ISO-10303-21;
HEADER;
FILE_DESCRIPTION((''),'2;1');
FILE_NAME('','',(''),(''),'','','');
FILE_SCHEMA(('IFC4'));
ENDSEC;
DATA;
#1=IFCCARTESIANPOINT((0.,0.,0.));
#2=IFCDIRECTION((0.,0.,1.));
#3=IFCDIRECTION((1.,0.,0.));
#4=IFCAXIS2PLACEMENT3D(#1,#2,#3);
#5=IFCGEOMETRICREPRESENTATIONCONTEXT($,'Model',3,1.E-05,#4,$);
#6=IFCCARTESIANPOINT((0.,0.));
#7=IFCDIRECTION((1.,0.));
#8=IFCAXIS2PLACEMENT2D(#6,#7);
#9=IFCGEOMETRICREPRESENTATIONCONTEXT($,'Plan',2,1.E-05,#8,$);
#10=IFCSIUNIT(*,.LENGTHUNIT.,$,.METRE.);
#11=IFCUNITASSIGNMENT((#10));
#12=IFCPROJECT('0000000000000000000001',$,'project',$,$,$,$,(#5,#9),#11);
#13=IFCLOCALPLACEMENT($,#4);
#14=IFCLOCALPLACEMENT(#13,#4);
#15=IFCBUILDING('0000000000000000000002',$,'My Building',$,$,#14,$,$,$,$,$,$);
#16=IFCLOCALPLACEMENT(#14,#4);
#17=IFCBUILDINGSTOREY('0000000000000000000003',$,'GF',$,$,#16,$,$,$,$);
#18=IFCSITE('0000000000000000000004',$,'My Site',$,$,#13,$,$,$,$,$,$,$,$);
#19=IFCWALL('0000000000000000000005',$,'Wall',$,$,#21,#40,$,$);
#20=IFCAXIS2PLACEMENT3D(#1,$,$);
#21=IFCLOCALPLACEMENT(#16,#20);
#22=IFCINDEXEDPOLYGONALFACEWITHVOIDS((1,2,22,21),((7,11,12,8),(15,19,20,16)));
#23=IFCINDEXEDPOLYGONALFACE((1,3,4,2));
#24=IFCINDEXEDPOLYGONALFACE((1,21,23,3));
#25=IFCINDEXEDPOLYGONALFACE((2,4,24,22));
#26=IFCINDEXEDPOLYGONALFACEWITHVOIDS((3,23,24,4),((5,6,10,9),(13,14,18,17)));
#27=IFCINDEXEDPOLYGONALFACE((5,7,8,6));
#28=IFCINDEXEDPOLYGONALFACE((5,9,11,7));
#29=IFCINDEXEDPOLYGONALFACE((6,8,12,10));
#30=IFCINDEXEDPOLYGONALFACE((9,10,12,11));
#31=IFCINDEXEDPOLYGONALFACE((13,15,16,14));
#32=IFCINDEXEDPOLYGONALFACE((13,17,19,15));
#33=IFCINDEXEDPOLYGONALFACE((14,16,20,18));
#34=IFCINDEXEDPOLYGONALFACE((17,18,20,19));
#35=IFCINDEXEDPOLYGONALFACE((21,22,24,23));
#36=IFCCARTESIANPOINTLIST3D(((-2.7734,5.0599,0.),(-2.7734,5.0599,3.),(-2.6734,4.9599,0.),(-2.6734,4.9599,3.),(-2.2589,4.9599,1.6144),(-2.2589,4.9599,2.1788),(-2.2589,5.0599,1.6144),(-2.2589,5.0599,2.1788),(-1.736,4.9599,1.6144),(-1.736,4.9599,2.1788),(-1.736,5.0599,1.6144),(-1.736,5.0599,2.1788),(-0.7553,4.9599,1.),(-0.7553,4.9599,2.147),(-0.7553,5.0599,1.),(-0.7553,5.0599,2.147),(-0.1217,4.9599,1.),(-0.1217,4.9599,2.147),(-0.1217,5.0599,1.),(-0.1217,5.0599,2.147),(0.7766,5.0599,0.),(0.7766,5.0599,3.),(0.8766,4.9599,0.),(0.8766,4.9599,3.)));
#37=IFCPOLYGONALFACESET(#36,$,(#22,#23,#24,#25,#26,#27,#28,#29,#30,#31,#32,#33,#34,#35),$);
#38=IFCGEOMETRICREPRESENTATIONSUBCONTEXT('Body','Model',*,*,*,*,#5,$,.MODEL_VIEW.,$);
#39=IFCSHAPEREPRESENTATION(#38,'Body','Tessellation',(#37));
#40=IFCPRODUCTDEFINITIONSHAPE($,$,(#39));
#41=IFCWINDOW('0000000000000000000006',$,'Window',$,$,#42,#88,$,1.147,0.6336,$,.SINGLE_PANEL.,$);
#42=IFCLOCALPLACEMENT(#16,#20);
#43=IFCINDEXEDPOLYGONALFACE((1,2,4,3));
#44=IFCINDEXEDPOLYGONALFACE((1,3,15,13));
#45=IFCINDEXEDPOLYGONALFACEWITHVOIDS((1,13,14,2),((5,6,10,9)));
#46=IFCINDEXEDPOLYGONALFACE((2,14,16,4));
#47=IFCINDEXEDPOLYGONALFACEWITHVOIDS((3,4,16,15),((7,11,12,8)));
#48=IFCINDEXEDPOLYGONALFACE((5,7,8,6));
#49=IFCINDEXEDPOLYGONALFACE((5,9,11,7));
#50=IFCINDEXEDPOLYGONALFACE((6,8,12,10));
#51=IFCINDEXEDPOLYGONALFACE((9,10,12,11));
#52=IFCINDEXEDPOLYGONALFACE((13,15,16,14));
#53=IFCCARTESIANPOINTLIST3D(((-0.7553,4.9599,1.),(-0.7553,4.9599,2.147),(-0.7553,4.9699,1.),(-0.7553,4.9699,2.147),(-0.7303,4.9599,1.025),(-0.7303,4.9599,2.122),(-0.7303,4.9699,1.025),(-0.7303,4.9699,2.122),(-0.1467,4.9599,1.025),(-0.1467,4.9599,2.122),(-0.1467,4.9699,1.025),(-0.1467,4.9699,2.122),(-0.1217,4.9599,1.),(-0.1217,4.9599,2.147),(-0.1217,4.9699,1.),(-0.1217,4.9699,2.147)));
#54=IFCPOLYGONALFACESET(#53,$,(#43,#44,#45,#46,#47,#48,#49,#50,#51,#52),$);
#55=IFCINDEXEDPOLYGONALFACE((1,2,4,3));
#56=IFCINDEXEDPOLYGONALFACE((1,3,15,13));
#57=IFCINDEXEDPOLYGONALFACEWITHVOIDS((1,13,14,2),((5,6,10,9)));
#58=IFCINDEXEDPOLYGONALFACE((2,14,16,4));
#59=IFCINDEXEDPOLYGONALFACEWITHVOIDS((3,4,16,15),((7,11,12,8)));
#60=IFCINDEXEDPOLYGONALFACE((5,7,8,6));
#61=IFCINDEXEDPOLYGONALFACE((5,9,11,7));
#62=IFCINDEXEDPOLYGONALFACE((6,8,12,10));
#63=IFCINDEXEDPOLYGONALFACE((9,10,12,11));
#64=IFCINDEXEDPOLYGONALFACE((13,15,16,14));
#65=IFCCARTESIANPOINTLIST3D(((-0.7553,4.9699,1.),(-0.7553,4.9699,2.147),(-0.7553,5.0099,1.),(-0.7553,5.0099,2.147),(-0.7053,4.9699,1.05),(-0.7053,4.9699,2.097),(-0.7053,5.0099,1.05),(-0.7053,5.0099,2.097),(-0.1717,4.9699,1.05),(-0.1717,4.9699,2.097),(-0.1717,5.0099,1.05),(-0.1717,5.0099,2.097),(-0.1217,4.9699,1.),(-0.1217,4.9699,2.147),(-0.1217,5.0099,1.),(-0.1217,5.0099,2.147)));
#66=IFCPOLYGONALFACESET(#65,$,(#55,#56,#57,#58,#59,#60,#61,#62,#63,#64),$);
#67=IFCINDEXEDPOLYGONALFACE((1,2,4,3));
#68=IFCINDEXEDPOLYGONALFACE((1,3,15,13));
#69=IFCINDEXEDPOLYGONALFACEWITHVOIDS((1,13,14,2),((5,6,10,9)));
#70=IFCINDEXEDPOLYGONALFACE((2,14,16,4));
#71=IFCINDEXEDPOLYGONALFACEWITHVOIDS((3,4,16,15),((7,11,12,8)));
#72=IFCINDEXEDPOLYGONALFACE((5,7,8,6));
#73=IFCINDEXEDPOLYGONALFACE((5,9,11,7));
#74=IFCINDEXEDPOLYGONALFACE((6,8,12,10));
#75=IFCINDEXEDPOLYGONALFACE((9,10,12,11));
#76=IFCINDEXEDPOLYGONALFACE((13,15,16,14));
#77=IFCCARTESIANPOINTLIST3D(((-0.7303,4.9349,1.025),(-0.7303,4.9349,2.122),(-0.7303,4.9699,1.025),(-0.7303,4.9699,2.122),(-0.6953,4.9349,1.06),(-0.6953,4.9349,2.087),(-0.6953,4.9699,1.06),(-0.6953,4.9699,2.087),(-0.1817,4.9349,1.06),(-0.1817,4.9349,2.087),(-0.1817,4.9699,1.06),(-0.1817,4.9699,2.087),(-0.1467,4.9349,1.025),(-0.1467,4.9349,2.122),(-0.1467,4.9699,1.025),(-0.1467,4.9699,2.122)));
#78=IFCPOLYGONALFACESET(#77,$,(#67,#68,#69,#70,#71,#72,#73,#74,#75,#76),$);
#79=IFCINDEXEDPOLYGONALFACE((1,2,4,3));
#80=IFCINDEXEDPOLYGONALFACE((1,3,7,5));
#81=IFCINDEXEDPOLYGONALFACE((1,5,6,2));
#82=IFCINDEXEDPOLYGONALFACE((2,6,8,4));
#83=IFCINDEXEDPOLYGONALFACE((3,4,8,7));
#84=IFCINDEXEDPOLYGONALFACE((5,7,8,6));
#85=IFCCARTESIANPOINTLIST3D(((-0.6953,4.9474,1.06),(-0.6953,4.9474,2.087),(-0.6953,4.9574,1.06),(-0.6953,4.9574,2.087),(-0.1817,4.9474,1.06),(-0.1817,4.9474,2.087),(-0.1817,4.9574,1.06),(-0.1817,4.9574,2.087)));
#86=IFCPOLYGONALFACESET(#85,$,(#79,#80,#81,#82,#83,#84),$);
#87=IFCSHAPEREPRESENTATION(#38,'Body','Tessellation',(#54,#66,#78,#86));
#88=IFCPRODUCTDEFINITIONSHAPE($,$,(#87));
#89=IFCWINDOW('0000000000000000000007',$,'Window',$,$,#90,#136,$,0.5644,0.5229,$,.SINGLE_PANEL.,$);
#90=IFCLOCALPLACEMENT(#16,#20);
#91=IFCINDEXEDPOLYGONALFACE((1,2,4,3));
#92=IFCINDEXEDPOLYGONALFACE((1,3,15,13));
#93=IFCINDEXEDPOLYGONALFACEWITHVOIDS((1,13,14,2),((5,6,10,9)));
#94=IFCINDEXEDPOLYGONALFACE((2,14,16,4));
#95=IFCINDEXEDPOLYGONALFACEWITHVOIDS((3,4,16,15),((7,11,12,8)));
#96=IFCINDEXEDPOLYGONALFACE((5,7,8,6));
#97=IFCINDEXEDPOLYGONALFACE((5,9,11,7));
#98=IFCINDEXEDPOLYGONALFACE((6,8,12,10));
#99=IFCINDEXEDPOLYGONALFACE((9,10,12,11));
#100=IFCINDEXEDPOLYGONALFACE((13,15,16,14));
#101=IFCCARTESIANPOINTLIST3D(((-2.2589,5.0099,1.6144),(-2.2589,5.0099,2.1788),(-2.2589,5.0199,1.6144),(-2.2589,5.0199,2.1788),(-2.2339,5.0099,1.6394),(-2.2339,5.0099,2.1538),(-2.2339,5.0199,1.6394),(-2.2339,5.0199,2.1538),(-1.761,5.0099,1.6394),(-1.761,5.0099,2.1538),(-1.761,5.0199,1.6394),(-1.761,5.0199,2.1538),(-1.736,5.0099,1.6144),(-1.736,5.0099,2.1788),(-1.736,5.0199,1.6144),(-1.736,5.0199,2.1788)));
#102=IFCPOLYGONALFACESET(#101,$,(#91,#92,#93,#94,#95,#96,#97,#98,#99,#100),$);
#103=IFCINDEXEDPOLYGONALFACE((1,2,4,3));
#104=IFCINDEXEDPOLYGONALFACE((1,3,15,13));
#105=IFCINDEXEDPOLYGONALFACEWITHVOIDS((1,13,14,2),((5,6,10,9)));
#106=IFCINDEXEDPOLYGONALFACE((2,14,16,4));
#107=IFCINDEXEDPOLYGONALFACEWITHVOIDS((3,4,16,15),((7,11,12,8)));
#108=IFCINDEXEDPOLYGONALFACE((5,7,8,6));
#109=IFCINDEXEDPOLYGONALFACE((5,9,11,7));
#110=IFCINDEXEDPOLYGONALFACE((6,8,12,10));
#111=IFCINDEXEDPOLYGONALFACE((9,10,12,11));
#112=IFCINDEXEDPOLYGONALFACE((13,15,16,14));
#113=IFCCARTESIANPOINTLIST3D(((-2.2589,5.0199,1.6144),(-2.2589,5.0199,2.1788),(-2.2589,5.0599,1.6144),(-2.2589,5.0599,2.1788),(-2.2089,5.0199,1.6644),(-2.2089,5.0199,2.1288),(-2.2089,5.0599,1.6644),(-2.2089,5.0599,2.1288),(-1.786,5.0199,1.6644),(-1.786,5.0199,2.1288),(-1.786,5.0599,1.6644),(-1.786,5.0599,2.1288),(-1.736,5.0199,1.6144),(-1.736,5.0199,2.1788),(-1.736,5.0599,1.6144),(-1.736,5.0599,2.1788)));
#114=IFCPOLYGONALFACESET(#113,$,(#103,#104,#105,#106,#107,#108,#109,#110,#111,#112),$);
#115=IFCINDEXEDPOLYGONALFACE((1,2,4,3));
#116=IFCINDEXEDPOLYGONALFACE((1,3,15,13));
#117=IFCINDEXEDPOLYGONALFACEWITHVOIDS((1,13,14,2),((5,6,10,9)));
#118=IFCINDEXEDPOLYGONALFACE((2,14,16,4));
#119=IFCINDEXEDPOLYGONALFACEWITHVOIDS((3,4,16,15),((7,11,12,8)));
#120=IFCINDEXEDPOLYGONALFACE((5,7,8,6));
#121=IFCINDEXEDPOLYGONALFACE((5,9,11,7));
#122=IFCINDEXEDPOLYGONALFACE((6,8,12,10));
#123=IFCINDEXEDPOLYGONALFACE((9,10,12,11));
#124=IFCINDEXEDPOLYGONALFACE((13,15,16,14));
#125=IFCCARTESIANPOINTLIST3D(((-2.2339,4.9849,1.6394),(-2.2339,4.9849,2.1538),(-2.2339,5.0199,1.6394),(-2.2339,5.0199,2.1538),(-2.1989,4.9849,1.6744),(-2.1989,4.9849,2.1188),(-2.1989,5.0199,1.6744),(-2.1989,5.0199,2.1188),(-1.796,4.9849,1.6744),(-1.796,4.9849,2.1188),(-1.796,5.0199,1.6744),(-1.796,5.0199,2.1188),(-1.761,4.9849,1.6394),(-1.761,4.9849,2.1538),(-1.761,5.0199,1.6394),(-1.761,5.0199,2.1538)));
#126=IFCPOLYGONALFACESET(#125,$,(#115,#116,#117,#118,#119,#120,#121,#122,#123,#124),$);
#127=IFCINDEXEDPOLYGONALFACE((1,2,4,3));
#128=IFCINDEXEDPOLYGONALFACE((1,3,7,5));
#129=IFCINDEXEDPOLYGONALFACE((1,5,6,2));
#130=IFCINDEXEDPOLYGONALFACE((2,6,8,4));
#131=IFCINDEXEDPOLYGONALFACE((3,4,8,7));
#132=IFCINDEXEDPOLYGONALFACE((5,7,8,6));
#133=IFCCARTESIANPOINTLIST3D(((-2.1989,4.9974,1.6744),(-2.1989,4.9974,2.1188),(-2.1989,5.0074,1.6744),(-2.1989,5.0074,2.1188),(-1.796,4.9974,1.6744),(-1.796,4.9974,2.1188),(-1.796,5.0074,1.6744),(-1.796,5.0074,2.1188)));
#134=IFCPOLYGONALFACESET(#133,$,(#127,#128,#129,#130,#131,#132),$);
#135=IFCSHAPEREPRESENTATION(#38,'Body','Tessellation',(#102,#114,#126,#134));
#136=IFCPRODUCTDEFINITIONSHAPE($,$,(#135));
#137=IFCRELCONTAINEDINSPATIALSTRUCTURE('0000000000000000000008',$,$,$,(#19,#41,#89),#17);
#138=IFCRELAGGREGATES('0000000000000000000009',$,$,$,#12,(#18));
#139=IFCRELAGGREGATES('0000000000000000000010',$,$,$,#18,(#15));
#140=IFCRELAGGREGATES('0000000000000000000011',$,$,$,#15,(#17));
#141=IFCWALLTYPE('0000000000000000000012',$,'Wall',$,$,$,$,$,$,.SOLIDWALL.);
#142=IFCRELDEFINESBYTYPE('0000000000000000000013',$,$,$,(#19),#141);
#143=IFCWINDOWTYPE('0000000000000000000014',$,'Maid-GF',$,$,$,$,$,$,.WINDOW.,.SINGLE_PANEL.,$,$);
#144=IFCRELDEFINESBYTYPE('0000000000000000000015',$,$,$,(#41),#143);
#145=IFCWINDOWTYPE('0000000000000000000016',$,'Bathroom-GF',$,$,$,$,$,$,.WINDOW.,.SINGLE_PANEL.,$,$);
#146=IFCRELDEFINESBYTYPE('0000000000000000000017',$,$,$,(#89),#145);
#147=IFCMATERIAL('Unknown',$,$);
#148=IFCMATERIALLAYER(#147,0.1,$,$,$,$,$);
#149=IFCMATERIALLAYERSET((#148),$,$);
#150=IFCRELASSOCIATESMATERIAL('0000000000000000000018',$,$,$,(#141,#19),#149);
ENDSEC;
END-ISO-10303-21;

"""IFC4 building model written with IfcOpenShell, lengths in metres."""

from ifc_helpers import new_model, entity, si_unit, frame, origin_with_axes, origin_2d_with_axis, place, context, subcontext, project, spatial, line, indexed_curve, outline, extrude, shape, source, transform, mapped, material, layer, layer_set, layer_usage, type_object, type_shapes, element, fill, save


model = new_model("IFC4")

# Units and contexts
model_context = context("Model", 3, precision=1e-05, world=origin_with_axes())
plan_context = context("Plan", 2, precision=1e-05, world=origin_2d_with_axis())
body_context_1 = subcontext(model_context, "Body", "Model", "MODEL_VIEW")
body_context_2 = subcontext(plan_context, "Body", "Plan", "PLAN_VIEW")
ifc_project = project(units=[si_unit("LENGTHUNIT", "METRE")], contexts=[model_context, plan_context])

# Site, building, storey
site_placement = place(None, origin_with_axes())
site = spatial("IfcSite", under=ifc_project, at=site_placement, Name="My Site")
building_placement = place(site_placement, origin_with_axes())
building = spatial("IfcBuilding", under=site, at=building_placement, Name="My Building")
storey_placement = place(building_placement, origin_with_axes())
storey = spatial("IfcBuildingStorey", under=building, at=storey_placement, Name="GF")

# Shared definitions
ifc_material = material(Name="Unknown")

# Shared definitions
ifc_layer_1 = layer(ifc_material, 0.1)
ifc_layer_set_1 = layer_set([ifc_layer_1])
wall_type = type_object("IfcWallType", Name="Wall", PredefinedType="SOLIDWALL", material=ifc_layer_set_1)

# Wall, openings, windows
ifc_layer_usage_1 = layer_usage(ifc_layer_set_1, "AXIS2", "POSITIVE", 0.0)
wall_1_placement = place(storey_placement, frame((0.7766, 5.0599, 0.0), z_axis=(0.0, 0.0, 1.0), x_axis=(-1.0, 0.0, 0.0)))
wall_1 = element("IfcWall", 1, at=wall_1_placement, inside=storey, type_object=wall_type, material=ifc_layer_usage_1, Name="Wall", context=body_context_1, shape_type="SweptSolid", body=[
    extrude(outline(indexed_curve([(0.0, 0.0), (-0.1, 0.1), (3.45, 0.1), (3.55, 0.0)], segments=[line(1, 2, 3, 4, 1)])), origin_with_axes(), (0.0, 0.0, 1.0), 3.0),
])
shared_shape_1 = source(origin_with_axes(), body_context_1, "Body", "SweptSolid", [
    extrude(outline(indexed_curve([(0.0, 0.0), (0.6336, 0.0), (0.6336, 1.147), (0.0, 1.147)], segments=[line(1, 2, 3, 4, 1)])), frame((0.0, -0.6, 0.0), z_axis=(0.0, -1.0, 0.0), x_axis=(1.0, 0.0, 0.0)), (0.0, 0.0, -1.0), 1.2),
])
opening_1_placement = place(wall_1_placement, frame((0.8983, 0.0, 1.0), z_axis=(0.0, 0.0, 1.0), x_axis=(1.0, 0.0, 0.0)))
opening_1 = element("IfcOpeningElement", 2, at=opening_1_placement, cuts=wall_1, PredefinedType="OPENING", context=body_context_1, shape_type="MappedRepresentation", body=[
    mapped(shared_shape_1, transform((0.0, 0.0, 0.0), x_axis=(1.0, 0.0, 0.0), y_axis=(0.0, 1.0, 0.0), z_axis=(0.0, 0.0, 1.0), scale=1.0)),
])
shared_shape_2 = source(origin_with_axes(), body_context_1, "Body", "SweptSolid", [
    extrude(outline(indexed_curve([(0.0, 0.0), (0.5229, 0.0), (0.5229, 0.5644), (0.0, 0.5644)], segments=[line(1, 2, 3, 4, 1)])), frame((0.0, -0.6, 0.0), z_axis=(0.0, -1.0, 0.0), x_axis=(1.0, 0.0, 0.0)), (0.0, 0.0, -1.0), 1.2),
])
opening_2_placement = place(wall_1_placement, frame((2.5126, -0.05, 1.6144), z_axis=(0.0, 0.0, 1.0), x_axis=(1.0, 0.0, 0.0)))
opening_2 = element("IfcOpeningElement", 3, at=opening_2_placement, cuts=wall_1, PredefinedType="OPENING", context=body_context_1, shape_type="MappedRepresentation", body=[
    mapped(shared_shape_2, transform((0.0, 0.0, 0.0), x_axis=(1.0, 0.0, 0.0), y_axis=(0.0, 1.0, 0.0), z_axis=(0.0, 0.0, 1.0), scale=1.0)),
])
window_type_1 = type_object("IfcWindowType", Name="Maid-GF", PartitioningType="SINGLE_PANEL", PredefinedType="WINDOW")
shared_shape_3 = source(origin_with_axes(), body_context_1, "Body", "SweptSolid", [
    extrude(outline(indexed_curve([(0.0, 0.0), (0.6336, 0.0), (0.6336, 1.147), (0.0, 1.147)], segments=[line(1, 2, 3, 4, 1)]), holes=[indexed_curve([(0.025, 0.025), (0.6086, 0.025), (0.6086, 1.122), (0.025, 1.122)], segments=[line(1, 2, 3, 4, 1)])]), frame((0.0, 0.09, 0.0), z_axis=(0.0, -1.0, 0.0), x_axis=(1.0, 0.0, 0.0)), (0.0, 0.0, -1.0), 0.01),
    extrude(outline(indexed_curve([(0.0, 0.0), (0.6336, 0.0), (0.6336, 1.147), (0.0, 1.147)], segments=[line(1, 2, 3, 4, 1)]), holes=[indexed_curve([(0.05, 0.05), (0.5836, 0.05), (0.5836, 1.097), (0.05, 1.097)], segments=[line(1, 2, 3, 4, 1)])]), frame((0.0, 0.05, 0.0), z_axis=(0.0, -1.0, 0.0), x_axis=(1.0, 0.0, 0.0)), (0.0, 0.0, -1.0), 0.04),
    extrude(outline(indexed_curve([(0.0, 0.0), (0.5836, 0.0), (0.5836, 1.097), (0.0, 1.097)], segments=[line(1, 2, 3, 4, 1)]), holes=[indexed_curve([(0.035, 0.035), (0.5486, 0.035), (0.5486, 1.062), (0.035, 1.062)], segments=[line(1, 2, 3, 4, 1)])]), frame((0.025, 0.09, 0.025), z_axis=(0.0, -1.0, 0.0), x_axis=(1.0, 0.0, 0.0)), (0.0, 0.0, -1.0), 0.035),
    extrude(outline(indexed_curve([(0.035, 0.035), (0.5486, 0.035), (0.5486, 1.062), (0.035, 1.062)], segments=[line(1, 2, 3, 4, 1)])), frame((0.025, 0.1025, 0.025), z_axis=(0.0, -1.0, 0.0), x_axis=(1.0, 0.0, 0.0)), (0.0, 0.0, -1.0), 0.01),
])
shared_shape_4 = source(origin_with_axes(), body_context_2, "Body", "Curve2D", [
    entity("IfcIndexedPolyCurve", entity("IfcCartesianPointList2D", [[0.05, 0.05], [0.5836, 0.05]])),
    entity("IfcIndexedPolyCurve", entity("IfcCartesianPointList2D", [[0.0, 0.1], [0.025, 0.1], [0.025, 0.09], [0.05, 0.09], [0.05, 0.05], [0.0, 0.05]]), [entity("IfcLineIndex", [1, 2, 3, 4, 5, 6, 1])]),
    entity("IfcIndexedPolyCurve", entity("IfcCartesianPointList2D", [[0.6336, 0.1], [0.6086, 0.1], [0.6086, 0.09], [0.5836, 0.09], [0.5836, 0.05], [0.6336, 0.05]]), [entity("IfcLineIndex", [1, 2, 3, 4, 5, 6, 1])]),
    entity("IfcIndexedPolyCurve", entity("IfcCartesianPointList2D", [[0.025, 0.09], [0.06, 0.09], [0.06, 0.125], [0.025, 0.125]]), [entity("IfcLineIndex", [1, 2, 3, 4, 1])]),
    entity("IfcIndexedPolyCurve", entity("IfcCartesianPointList2D", [[0.6086, 0.09], [0.5736, 0.09], [0.5736, 0.125], [0.6086, 0.125]]), [entity("IfcLineIndex", [1, 2, 3, 4, 1])]),
    entity("IfcIndexedPolyCurve", entity("IfcCartesianPointList2D", [[0.06, 0.09], [0.5736, 0.09]])),
    entity("IfcIndexedPolyCurve", entity("IfcCartesianPointList2D", [[0.06, 0.125], [0.5736, 0.125]])),
    entity("IfcIndexedPolyCurve", entity("IfcCartesianPointList2D", [[0.06, 0.1075], [0.5736, 0.1075]])),
])
type_shapes(window_type_1, [shared_shape_3, shared_shape_4])
window_1_placement = place(opening_1_placement, frame((0.0, 0.0, 0.0), z_axis=(0.0, 0.0, 1.0), x_axis=(1.0, 0.0, 0.0)))
window_1 = element("IfcWindow", 4, at=window_1_placement, inside=storey, type_object=window_type_1, Name="Window", OverallHeight=1.147, OverallWidth=0.6336, PartitioningType="SINGLE_PANEL", shapes=[
    shape(body_context_1, "Body", "MappedRepresentation", [mapped(shared_shape_3, transform((0.0, 0.0, 0.0), x_axis=(1.0, 0.0, 0.0), y_axis=(0.0, 1.0, 0.0), z_axis=(0.0, 0.0, 1.0), scale=1.0))]),
    shape(body_context_2, "Body", "MappedRepresentation", [mapped(shared_shape_4, transform((0.0, 0.0, 0.0), x_axis=(1.0, 0.0, 0.0), y_axis=(0.0, 1.0, 0.0), z_axis=(0.0, 0.0, 1.0), scale=1.0))]),
])
fill(opening_1, window_1)
window_type_2 = type_object("IfcWindowType", Name="Bathroom-GF", PartitioningType="SINGLE_PANEL", PredefinedType="WINDOW")
shared_shape_5 = source(origin_with_axes(), body_context_1, "Body", "SweptSolid", [
    extrude(outline(indexed_curve([(0.0, 0.0), (0.5229, 0.0), (0.5229, 0.5644), (0.0, 0.5644)], segments=[line(1, 2, 3, 4, 1)]), holes=[indexed_curve([(0.025, 0.025), (0.4979, 0.025), (0.4979, 0.5394), (0.025, 0.5394)], segments=[line(1, 2, 3, 4, 1)])]), frame((0.0, 0.09, 0.0), z_axis=(0.0, -1.0, 0.0), x_axis=(1.0, 0.0, 0.0)), (0.0, 0.0, -1.0), 0.01),
    extrude(outline(indexed_curve([(0.0, 0.0), (0.5229, 0.0), (0.5229, 0.5644), (0.0, 0.5644)], segments=[line(1, 2, 3, 4, 1)]), holes=[indexed_curve([(0.05, 0.05), (0.4729, 0.05), (0.4729, 0.5144), (0.05, 0.5144)], segments=[line(1, 2, 3, 4, 1)])]), frame((0.0, 0.05, 0.0), z_axis=(0.0, -1.0, 0.0), x_axis=(1.0, 0.0, 0.0)), (0.0, 0.0, -1.0), 0.04),
    extrude(outline(indexed_curve([(0.0, 0.0), (0.4729, 0.0), (0.4729, 0.5144), (0.0, 0.5144)], segments=[line(1, 2, 3, 4, 1)]), holes=[indexed_curve([(0.035, 0.035), (0.4379, 0.035), (0.4379, 0.4794), (0.035, 0.4794)], segments=[line(1, 2, 3, 4, 1)])]), frame((0.025, 0.09, 0.025), z_axis=(0.0, -1.0, 0.0), x_axis=(1.0, 0.0, 0.0)), (0.0, 0.0, -1.0), 0.035),
    extrude(outline(indexed_curve([(0.035, 0.035), (0.4379, 0.035), (0.4379, 0.4794), (0.035, 0.4794)], segments=[line(1, 2, 3, 4, 1)])), frame((0.025, 0.1025, 0.025), z_axis=(0.0, -1.0, 0.0), x_axis=(1.0, 0.0, 0.0)), (0.0, 0.0, -1.0), 0.01),
])
shared_shape_6 = source(origin_with_axes(), body_context_2, "Body", "Curve2D", [
    entity("IfcIndexedPolyCurve", entity("IfcCartesianPointList2D", [[0.05, 0.05], [0.4729, 0.05]])),
    entity("IfcIndexedPolyCurve", entity("IfcCartesianPointList2D", [[0.0, 0.1], [0.025, 0.1], [0.025, 0.09], [0.05, 0.09], [0.05, 0.05], [0.0, 0.05]]), [entity("IfcLineIndex", [1, 2, 3, 4, 5, 6, 1])]),
    entity("IfcIndexedPolyCurve", entity("IfcCartesianPointList2D", [[0.5229, 0.1], [0.4979, 0.1], [0.4979, 0.09], [0.4729, 0.09], [0.4729, 0.05], [0.5229, 0.05]]), [entity("IfcLineIndex", [1, 2, 3, 4, 5, 6, 1])]),
    entity("IfcIndexedPolyCurve", entity("IfcCartesianPointList2D", [[0.025, 0.09], [0.06, 0.09], [0.06, 0.125], [0.025, 0.125]]), [entity("IfcLineIndex", [1, 2, 3, 4, 1])]),
    entity("IfcIndexedPolyCurve", entity("IfcCartesianPointList2D", [[0.4979, 0.09], [0.4629, 0.09], [0.4629, 0.125], [0.4979, 0.125]]), [entity("IfcLineIndex", [1, 2, 3, 4, 1])]),
    entity("IfcIndexedPolyCurve", entity("IfcCartesianPointList2D", [[0.06, 0.09], [0.4629, 0.09]])),
    entity("IfcIndexedPolyCurve", entity("IfcCartesianPointList2D", [[0.06, 0.125], [0.4629, 0.125]])),
    entity("IfcIndexedPolyCurve", entity("IfcCartesianPointList2D", [[0.06, 0.1075], [0.4629, 0.1075]])),
])
type_shapes(window_type_2, [shared_shape_5, shared_shape_6])
window_2_placement = place(opening_2_placement, frame((0.0, 0.0, 0.0), z_axis=(0.0, 0.0, 1.0), x_axis=(1.0, 0.0, 0.0)))
window_2 = element("IfcWindow", 5, at=window_2_placement, inside=storey, type_object=window_type_2, Name="Window", OverallHeight=0.5644, OverallWidth=0.5229, PartitioningType="SINGLE_PANEL", shapes=[
    shape(body_context_1, "Body", "MappedRepresentation", [mapped(shared_shape_5, transform((0.0, 0.0, 0.0), x_axis=(1.0, 0.0, 0.0), y_axis=(0.0, 1.0, 0.0), z_axis=(0.0, 0.0, 1.0), scale=1.0))]),
    shape(body_context_2, "Body", "MappedRepresentation", [mapped(shared_shape_6, transform((0.0, 0.0, 0.0), x_axis=(1.0, 0.0, 0.0), y_axis=(0.0, 1.0, 0.0), z_axis=(0.0, 0.0, 1.0), scale=1.0))]),
])
fill(opening_2, window_2)

save(model, "model.ifc")
